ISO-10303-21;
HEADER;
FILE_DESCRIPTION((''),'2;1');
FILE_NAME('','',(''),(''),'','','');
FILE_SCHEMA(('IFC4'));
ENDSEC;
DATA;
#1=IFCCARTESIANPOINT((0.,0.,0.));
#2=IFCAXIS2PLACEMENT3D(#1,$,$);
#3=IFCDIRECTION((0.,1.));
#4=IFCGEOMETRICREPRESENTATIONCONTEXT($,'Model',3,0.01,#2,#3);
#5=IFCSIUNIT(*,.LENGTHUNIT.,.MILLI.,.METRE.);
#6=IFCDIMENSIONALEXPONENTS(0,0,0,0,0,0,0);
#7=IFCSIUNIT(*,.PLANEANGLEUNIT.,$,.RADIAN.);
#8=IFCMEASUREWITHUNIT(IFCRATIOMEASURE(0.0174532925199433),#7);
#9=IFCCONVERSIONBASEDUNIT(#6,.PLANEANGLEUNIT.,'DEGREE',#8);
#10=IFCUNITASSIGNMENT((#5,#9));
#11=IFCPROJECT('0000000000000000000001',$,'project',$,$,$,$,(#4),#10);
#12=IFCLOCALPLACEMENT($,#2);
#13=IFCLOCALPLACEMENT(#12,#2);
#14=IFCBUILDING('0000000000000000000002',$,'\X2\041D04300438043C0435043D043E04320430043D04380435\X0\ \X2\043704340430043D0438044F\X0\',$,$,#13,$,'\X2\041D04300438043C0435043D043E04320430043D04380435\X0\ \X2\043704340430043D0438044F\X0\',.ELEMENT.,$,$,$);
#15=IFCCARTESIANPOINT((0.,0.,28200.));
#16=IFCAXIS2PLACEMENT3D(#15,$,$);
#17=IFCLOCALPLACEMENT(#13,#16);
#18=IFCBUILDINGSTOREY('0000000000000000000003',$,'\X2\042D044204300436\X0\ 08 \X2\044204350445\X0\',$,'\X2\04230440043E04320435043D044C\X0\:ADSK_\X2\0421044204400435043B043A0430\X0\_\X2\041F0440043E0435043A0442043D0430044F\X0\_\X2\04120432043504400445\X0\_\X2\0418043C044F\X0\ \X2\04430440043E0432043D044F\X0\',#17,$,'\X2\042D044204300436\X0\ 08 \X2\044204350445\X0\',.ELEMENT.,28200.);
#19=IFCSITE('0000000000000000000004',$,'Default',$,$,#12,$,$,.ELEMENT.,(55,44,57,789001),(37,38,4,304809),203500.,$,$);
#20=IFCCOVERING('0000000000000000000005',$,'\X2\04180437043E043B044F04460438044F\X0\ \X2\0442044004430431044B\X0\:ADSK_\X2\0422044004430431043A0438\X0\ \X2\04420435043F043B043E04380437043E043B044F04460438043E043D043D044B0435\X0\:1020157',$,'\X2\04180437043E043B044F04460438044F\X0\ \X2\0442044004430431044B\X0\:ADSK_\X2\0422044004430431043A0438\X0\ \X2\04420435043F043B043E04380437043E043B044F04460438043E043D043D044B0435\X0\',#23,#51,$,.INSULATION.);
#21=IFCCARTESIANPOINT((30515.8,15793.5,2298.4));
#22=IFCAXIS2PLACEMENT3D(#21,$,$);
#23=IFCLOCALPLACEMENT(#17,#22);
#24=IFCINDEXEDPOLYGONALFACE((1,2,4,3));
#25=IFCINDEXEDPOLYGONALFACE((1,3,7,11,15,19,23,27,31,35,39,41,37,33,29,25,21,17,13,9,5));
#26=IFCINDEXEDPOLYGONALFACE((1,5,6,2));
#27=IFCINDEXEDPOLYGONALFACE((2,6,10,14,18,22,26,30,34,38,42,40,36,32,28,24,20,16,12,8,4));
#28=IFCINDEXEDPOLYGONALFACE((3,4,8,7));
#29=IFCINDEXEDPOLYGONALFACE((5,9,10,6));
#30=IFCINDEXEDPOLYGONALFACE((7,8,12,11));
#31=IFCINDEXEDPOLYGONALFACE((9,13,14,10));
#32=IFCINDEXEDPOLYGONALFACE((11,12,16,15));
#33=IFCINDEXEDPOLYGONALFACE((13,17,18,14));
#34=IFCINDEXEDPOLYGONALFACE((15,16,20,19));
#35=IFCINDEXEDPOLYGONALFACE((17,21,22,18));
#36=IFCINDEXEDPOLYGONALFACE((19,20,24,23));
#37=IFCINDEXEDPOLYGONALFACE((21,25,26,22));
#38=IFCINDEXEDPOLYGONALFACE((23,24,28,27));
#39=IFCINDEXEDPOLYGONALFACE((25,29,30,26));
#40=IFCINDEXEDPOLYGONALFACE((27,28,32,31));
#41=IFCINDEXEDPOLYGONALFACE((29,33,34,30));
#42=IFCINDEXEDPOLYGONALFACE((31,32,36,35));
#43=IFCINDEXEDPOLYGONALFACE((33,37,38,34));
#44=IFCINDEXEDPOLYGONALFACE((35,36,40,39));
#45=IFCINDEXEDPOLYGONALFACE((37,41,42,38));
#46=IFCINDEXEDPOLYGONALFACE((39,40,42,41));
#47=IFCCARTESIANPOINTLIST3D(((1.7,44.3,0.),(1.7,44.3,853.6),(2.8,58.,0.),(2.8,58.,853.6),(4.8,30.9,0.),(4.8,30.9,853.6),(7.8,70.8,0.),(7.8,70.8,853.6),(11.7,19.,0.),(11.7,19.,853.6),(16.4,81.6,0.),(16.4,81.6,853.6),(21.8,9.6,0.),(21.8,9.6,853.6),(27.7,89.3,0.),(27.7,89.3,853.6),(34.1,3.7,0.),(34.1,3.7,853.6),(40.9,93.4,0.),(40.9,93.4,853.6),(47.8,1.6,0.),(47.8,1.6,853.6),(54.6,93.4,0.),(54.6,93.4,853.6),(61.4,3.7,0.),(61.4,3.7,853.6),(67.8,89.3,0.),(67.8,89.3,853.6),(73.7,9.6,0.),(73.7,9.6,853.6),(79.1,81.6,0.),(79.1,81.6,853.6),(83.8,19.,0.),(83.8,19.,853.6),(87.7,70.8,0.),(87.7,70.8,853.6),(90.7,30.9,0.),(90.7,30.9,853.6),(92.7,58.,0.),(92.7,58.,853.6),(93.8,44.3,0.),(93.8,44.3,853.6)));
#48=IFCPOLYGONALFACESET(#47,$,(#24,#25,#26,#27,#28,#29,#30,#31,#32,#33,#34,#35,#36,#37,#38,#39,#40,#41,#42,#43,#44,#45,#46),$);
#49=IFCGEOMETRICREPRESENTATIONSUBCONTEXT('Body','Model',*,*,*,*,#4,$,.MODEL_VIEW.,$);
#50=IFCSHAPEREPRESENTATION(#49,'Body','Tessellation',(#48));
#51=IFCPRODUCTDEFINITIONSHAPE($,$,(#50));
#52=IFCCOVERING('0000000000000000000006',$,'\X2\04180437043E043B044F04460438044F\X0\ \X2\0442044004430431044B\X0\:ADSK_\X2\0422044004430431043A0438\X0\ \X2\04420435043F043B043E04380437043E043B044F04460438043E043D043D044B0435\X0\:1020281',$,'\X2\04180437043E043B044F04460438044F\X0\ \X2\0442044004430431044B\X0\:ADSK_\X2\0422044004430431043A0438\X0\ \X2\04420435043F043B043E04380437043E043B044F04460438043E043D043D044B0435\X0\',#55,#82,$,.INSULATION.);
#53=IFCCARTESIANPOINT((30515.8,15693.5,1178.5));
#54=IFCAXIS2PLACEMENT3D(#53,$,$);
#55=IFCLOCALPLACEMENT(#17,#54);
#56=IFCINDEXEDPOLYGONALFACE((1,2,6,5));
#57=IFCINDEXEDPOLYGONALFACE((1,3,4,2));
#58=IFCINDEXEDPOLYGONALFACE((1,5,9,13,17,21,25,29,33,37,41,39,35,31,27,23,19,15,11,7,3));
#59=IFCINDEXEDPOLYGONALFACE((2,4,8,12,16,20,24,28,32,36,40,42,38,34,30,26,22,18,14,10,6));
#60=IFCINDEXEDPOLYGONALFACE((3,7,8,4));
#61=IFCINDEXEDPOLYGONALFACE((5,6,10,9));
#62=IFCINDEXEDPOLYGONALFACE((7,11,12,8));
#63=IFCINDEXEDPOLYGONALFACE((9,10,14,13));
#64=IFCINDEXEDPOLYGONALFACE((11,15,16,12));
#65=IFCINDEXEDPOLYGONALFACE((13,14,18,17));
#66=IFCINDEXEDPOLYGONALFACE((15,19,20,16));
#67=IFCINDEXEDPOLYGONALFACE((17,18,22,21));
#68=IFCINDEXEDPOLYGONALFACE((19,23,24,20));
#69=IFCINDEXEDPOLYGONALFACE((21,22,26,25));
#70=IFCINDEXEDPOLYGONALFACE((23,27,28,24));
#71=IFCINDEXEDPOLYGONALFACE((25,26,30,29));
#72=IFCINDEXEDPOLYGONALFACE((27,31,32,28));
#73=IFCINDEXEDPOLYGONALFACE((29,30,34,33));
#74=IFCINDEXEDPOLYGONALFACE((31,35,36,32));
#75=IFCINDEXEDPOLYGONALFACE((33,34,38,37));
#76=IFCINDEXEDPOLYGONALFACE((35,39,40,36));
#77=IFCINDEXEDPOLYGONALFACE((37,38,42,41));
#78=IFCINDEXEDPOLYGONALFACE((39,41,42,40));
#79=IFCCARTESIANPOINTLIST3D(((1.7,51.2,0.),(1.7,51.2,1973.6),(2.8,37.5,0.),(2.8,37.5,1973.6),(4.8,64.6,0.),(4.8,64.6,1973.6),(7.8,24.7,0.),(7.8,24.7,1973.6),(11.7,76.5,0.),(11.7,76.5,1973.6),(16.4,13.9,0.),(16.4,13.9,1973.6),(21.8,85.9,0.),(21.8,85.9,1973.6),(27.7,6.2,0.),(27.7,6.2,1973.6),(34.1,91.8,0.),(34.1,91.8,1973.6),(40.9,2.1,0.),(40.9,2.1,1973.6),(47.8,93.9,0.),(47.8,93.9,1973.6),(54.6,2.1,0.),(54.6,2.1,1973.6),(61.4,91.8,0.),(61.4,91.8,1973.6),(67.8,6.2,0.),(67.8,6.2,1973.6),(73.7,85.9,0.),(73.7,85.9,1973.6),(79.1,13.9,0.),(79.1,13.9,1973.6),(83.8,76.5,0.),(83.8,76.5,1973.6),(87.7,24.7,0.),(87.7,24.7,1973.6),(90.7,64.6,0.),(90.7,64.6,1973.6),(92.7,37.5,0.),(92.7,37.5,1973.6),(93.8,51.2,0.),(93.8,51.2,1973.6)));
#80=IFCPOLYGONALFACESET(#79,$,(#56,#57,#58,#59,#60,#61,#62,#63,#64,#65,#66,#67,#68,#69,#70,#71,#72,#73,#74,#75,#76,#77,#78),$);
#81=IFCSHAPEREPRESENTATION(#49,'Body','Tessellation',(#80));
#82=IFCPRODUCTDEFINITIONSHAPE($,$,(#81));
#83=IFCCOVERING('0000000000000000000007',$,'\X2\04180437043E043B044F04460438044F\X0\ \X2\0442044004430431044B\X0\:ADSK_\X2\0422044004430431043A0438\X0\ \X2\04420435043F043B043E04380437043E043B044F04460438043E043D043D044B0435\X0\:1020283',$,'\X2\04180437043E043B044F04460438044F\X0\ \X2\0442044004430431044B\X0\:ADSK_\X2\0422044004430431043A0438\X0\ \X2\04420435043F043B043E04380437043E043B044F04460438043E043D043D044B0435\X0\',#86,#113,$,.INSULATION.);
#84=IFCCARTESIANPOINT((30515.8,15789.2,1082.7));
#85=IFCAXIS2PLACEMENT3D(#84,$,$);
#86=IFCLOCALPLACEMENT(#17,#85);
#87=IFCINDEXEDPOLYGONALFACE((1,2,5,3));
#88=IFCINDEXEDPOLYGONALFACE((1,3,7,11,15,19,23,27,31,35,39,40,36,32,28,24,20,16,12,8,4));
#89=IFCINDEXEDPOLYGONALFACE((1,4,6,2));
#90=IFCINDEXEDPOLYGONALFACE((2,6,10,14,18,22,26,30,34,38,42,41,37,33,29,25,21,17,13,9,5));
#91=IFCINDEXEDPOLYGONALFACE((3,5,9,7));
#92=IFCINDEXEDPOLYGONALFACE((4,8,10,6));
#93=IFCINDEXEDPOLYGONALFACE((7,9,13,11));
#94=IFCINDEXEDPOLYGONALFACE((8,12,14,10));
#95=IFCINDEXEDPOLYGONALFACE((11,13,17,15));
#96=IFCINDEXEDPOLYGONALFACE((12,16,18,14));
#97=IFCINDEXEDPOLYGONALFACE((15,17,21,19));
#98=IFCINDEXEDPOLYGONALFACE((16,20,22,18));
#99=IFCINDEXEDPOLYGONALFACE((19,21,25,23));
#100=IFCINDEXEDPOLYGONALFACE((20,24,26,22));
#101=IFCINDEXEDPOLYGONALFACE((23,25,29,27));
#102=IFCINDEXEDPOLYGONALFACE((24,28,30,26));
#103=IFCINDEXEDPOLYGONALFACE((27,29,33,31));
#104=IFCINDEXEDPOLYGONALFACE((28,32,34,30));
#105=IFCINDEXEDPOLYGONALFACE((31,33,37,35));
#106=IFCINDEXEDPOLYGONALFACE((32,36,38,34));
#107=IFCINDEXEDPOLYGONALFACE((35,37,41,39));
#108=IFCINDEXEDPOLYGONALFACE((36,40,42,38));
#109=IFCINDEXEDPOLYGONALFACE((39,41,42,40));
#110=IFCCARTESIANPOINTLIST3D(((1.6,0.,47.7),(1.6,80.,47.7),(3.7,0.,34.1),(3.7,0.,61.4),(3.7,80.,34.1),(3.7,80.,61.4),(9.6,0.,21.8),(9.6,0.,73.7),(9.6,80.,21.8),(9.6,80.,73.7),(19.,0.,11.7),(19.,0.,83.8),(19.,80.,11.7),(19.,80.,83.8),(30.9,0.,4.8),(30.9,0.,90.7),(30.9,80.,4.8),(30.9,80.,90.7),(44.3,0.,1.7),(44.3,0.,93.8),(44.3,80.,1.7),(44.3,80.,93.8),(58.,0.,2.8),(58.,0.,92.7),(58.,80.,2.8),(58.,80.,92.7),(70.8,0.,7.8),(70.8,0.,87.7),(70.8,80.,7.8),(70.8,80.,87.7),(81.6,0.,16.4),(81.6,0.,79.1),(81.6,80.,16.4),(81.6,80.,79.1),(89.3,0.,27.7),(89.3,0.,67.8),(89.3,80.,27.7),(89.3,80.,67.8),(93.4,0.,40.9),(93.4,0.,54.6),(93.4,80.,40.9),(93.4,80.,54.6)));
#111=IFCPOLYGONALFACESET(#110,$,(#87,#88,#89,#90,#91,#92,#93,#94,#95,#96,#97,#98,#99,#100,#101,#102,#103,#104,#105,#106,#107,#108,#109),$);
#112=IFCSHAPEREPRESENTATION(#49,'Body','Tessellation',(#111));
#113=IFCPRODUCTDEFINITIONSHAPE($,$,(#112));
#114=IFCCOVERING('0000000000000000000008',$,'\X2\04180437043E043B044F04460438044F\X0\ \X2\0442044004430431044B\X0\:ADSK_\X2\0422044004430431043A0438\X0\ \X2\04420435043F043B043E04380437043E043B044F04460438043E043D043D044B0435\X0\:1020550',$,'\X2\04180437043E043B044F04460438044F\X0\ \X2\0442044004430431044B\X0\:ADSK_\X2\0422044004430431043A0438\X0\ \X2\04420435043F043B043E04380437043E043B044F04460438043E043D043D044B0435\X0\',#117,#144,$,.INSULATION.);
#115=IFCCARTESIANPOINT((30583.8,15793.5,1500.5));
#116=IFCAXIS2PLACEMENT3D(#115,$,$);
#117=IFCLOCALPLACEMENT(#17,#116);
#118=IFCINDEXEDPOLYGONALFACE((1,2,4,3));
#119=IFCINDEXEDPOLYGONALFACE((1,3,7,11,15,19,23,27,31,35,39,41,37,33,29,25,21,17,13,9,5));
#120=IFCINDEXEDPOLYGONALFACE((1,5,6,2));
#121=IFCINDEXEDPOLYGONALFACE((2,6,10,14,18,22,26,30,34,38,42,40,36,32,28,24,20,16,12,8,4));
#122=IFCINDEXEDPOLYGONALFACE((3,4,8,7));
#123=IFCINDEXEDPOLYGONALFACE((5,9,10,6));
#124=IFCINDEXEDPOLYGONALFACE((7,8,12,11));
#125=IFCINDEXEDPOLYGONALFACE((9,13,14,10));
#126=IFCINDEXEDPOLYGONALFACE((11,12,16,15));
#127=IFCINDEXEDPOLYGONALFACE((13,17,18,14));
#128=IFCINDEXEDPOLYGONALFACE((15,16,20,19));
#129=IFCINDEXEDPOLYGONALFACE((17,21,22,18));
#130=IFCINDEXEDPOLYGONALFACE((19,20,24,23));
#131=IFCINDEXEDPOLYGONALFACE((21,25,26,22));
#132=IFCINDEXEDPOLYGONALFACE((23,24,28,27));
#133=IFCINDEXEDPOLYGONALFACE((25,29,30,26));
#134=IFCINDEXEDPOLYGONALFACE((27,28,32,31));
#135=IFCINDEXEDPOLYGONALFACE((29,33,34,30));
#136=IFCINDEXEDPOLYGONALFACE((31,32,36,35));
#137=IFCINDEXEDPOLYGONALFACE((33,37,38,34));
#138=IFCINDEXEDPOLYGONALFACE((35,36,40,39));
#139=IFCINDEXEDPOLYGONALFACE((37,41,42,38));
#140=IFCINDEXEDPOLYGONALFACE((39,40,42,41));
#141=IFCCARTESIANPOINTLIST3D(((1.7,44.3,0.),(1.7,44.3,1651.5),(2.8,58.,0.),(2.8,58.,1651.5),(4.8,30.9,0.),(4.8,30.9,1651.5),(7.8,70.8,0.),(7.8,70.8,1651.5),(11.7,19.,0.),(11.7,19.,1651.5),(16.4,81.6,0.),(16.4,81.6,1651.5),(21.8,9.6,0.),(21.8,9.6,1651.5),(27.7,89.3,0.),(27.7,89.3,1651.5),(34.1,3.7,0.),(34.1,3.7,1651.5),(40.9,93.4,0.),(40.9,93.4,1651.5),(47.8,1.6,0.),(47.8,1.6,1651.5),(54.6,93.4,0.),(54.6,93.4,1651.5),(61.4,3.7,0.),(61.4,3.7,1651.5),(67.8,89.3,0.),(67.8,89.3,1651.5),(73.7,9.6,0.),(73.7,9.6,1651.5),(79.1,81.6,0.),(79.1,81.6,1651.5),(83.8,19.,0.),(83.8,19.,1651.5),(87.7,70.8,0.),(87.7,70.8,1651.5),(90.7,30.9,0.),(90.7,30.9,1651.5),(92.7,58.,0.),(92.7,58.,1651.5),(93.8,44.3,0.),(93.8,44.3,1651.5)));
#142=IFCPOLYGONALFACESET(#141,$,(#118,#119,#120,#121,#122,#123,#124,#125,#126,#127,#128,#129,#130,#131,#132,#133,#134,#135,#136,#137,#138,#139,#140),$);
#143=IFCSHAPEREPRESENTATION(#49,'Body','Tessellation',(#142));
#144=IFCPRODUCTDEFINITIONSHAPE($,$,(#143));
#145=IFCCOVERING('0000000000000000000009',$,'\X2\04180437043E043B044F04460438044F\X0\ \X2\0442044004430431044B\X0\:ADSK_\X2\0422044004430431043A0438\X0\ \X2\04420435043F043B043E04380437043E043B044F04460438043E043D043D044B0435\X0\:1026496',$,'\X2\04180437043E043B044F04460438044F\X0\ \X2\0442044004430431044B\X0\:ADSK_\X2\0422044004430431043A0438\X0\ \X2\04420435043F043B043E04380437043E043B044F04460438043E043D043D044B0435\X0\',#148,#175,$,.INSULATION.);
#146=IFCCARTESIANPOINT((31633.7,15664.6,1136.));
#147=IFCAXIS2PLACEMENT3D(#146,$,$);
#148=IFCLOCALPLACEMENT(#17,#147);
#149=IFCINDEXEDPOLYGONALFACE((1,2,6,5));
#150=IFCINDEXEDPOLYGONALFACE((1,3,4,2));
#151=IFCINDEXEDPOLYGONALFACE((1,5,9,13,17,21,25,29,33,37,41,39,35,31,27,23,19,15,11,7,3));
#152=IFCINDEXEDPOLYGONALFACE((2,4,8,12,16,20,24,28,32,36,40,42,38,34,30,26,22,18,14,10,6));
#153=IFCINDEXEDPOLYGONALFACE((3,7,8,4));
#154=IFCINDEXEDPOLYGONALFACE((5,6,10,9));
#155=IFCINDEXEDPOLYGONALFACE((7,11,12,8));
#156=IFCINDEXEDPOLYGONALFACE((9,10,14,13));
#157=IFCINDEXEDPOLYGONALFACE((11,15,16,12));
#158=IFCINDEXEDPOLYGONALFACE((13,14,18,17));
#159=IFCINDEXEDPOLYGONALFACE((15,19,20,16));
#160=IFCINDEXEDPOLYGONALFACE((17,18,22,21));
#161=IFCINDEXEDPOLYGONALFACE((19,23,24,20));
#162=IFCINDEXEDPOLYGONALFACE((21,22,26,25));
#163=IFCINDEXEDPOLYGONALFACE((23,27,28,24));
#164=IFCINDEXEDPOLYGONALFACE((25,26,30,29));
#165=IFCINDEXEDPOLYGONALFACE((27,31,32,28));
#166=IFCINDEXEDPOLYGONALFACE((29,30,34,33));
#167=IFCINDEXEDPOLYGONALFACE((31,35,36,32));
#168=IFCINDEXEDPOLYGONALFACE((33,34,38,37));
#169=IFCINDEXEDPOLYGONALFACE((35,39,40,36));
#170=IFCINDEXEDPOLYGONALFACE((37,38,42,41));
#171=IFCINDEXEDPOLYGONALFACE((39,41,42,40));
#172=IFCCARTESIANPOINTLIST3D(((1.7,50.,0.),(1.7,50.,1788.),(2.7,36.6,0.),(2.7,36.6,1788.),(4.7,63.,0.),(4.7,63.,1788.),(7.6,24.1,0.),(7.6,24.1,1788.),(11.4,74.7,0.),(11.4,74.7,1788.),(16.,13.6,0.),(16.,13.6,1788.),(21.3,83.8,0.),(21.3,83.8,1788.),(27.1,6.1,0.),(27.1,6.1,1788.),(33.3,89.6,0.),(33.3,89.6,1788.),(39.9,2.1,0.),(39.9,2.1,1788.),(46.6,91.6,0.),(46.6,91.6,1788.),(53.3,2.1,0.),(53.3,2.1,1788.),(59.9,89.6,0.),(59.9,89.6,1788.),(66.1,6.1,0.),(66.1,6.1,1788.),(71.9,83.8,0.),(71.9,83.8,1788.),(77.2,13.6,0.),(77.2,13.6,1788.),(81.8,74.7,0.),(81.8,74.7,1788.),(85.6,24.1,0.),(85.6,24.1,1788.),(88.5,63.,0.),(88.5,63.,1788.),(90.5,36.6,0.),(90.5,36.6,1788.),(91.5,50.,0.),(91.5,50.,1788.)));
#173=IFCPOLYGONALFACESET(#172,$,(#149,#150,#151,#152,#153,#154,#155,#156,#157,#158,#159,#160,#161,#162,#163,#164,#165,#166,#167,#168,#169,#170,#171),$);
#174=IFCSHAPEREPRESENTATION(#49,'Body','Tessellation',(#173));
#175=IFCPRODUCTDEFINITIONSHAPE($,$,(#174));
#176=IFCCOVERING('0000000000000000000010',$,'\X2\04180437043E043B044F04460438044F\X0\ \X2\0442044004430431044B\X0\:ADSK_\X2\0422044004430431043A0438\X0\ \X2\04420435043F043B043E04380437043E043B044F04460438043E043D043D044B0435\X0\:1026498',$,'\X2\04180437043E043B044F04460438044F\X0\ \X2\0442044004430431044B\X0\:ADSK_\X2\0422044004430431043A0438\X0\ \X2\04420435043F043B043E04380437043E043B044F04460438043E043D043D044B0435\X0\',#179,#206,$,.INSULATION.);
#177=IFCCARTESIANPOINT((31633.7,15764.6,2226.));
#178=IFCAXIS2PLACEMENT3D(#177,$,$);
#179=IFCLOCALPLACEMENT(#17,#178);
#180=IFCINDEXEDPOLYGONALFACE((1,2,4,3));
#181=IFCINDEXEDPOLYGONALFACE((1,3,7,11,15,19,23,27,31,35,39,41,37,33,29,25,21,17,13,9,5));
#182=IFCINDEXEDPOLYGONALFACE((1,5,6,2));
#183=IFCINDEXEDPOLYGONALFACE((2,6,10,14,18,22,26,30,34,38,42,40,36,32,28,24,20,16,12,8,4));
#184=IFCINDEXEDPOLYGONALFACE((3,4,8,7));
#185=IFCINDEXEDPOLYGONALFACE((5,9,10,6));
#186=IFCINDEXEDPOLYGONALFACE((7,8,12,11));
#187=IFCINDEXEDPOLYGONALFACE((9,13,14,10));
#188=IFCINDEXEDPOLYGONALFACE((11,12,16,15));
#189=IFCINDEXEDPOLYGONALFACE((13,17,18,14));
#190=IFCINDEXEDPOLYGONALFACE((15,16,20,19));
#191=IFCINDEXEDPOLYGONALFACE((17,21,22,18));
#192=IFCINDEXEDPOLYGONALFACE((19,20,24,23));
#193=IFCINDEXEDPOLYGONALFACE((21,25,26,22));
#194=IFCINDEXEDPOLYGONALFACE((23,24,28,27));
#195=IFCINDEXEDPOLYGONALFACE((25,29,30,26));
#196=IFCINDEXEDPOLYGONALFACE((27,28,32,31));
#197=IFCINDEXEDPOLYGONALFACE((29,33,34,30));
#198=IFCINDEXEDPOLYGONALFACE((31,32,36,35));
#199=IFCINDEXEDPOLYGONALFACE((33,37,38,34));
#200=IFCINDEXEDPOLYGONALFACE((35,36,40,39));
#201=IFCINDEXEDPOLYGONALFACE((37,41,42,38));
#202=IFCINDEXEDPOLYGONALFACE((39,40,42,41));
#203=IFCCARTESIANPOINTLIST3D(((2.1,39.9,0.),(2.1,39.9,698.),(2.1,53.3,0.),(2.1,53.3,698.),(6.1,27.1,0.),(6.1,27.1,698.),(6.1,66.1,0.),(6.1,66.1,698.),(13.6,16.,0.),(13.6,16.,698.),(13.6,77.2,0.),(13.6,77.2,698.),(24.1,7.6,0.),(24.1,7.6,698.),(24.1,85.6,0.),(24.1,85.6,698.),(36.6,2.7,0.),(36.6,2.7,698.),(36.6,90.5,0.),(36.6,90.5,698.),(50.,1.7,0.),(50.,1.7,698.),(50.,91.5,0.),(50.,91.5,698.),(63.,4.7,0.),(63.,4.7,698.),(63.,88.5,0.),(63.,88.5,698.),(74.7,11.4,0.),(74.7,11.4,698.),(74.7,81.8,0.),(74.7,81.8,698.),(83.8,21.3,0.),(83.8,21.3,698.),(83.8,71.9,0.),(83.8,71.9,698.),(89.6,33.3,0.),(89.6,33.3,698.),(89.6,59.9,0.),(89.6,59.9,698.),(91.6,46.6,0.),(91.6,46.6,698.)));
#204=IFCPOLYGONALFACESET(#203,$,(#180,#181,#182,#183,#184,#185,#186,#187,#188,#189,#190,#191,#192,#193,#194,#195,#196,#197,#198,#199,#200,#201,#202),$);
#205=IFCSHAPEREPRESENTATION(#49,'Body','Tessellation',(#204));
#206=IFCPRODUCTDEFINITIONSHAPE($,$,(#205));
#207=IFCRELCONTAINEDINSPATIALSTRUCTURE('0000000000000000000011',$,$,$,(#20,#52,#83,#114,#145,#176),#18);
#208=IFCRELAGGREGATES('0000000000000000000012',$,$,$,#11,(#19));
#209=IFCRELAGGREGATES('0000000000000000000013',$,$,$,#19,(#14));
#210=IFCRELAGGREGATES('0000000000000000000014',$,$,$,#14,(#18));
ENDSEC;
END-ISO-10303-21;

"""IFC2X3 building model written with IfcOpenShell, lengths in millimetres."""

from ifc_helpers import new_model, entity, si_unit, converted_unit, direction, frame, origin, origin_2d_with_axis, place, context, subcontext, project, spatial, circle, extrude, element, save


model = new_model("IFC2X3")

# Units and contexts
model_context = context("Model", 3, precision=0.01, world=origin(), true_north=direction((0.0, 1.0)))
body_context = subcontext(model_context, "Body", "Model", "MODEL_VIEW")
ifc_project = project(units=[si_unit("LENGTHUNIT", "METRE", prefix="MILLI"), converted_unit("PLANEANGLEUNIT", "DEGREE", entity("IfcRatioMeasure", 0.0174532925199433), si_unit("PLANEANGLEUNIT", "RADIAN"), dimensions=[0, 0, 0, 0, 0, 0, 0])], contexts=[model_context])

# Site, building, storey
site_placement = place(None, origin())
site = spatial("IfcSite", under=ifc_project, at=site_placement, Name="Default", CompositionType="ELEMENT", RefLatitude=(55, 44, 57, 789001), RefLongitude=(37, 38, 4, 304809), RefElevation=203500.0)
building_placement = place(site_placement, origin())
building = spatial("IfcBuilding", under=site, at=building_placement, Name="Наименование здания", LongName="Наименование здания", CompositionType="ELEMENT")
storey_placement = place(building_placement, frame((0.0, 0.0, 28200.0)))
storey = spatial("IfcBuildingStorey", under=building, at=storey_placement, Name="Этаж 08 тех", ObjectType="Уровень:ADSK_Стрелка_Проектная_Вверх_Имя уровня", LongName="Этаж 08 тех", CompositionType="ELEMENT", Elevation=28200.0)

# Coverings
covering_1_placement = place(storey_placement, frame((30515.8, 15793.5, 2298.4)))
element("IfcCovering", 1, at=covering_1_placement, inside=storey, Name="Изоляция трубы:ADSK_Трубки теплоизоляционные:1020157", ObjectType="Изоляция трубы:ADSK_Трубки теплоизоляционные", PredefinedType="INSULATION", context=body_context, shape_type="SweptSolid", body=[
    extrude(circle(Radius=46.1, at=origin_2d_with_axis()), frame((47.8, 47.8, 0.0), z_axis=(0.0, 0.0, 1.0), x_axis=(0.0, -1.0, 0.0)), (0.0, 0.0, 1.0), 853.6),
])
covering_2_placement = place(storey_placement, frame((30515.8, 15693.5, 1178.5)))
element("IfcCovering", 2, at=covering_2_placement, inside=storey, Name="Изоляция трубы:ADSK_Трубки теплоизоляционные:1020281", ObjectType="Изоляция трубы:ADSK_Трубки теплоизоляционные", PredefinedType="INSULATION", context=body_context, shape_type="SweptSolid", body=[
    extrude(circle(Radius=46.1, at=origin_2d_with_axis()), frame((47.8, 47.8, 0.0), z_axis=(0.0, 0.0, 1.0), x_axis=(0.0, 1.0, 0.0)), (0.0, 0.0, 1.0), 1973.6),
])
covering_3_placement = place(storey_placement, frame((30515.8, 15789.2, 1082.7)))
element("IfcCovering", 3, at=covering_3_placement, inside=storey, Name="Изоляция трубы:ADSK_Трубки теплоизоляционные:1020283", ObjectType="Изоляция трубы:ADSK_Трубки теплоизоляционные", PredefinedType="INSULATION", context=body_context, shape_type="SweptSolid", body=[
    extrude(circle(Radius=46.1, at=origin_2d_with_axis()), frame((47.8, 0.0, 47.8), z_axis=(0.0, 1.0, 0.0), x_axis=(-1.0, 0.0, 0.0)), (0.0, 0.0, 1.0), 80.0),
])
covering_4_placement = place(storey_placement, frame((30583.8, 15793.5, 1500.5)))
element("IfcCovering", 4, at=covering_4_placement, inside=storey, Name="Изоляция трубы:ADSK_Трубки теплоизоляционные:1020550", ObjectType="Изоляция трубы:ADSK_Трубки теплоизоляционные", PredefinedType="INSULATION", context=body_context, shape_type="SweptSolid", body=[
    extrude(circle(Radius=46.1, at=origin_2d_with_axis()), frame((47.8, 47.8, 0.0), z_axis=(0.0, 0.0, 1.0), x_axis=(0.0, -1.0, 0.0)), (0.0, 0.0, 1.0), 1651.5),
])
covering_5_placement = place(storey_placement, frame((31633.7, 15664.6, 1136.0)))
element("IfcCovering", 5, at=covering_5_placement, inside=storey, Name="Изоляция трубы:ADSK_Трубки теплоизоляционные:1026496", ObjectType="Изоляция трубы:ADSK_Трубки теплоизоляционные", PredefinedType="INSULATION", context=body_context, shape_type="SweptSolid", body=[
    extrude(circle(Radius=45.0, at=origin_2d_with_axis()), frame((46.6, 46.6, 0.0), z_axis=(0.0, 0.0, 1.0), x_axis=(0.0, 1.0, 0.0)), (0.0, 0.0, 1.0), 1788.0),
])
covering_6_placement = place(storey_placement, frame((31633.7, 15764.6, 2226.0)))
element("IfcCovering", 6, at=covering_6_placement, inside=storey, Name="Изоляция трубы:ADSK_Трубки теплоизоляционные:1026498", ObjectType="Изоляция трубы:ADSK_Трубки теплоизоляционные", PredefinedType="INSULATION", context=body_context, shape_type="SweptSolid", body=[
    extrude(circle(Radius=45.0, at=origin_2d_with_axis()), frame((46.6, 46.6, 0.0)), (0.0, 0.0, 1.0), 698.0),
])

save(model, "model.ifc")
